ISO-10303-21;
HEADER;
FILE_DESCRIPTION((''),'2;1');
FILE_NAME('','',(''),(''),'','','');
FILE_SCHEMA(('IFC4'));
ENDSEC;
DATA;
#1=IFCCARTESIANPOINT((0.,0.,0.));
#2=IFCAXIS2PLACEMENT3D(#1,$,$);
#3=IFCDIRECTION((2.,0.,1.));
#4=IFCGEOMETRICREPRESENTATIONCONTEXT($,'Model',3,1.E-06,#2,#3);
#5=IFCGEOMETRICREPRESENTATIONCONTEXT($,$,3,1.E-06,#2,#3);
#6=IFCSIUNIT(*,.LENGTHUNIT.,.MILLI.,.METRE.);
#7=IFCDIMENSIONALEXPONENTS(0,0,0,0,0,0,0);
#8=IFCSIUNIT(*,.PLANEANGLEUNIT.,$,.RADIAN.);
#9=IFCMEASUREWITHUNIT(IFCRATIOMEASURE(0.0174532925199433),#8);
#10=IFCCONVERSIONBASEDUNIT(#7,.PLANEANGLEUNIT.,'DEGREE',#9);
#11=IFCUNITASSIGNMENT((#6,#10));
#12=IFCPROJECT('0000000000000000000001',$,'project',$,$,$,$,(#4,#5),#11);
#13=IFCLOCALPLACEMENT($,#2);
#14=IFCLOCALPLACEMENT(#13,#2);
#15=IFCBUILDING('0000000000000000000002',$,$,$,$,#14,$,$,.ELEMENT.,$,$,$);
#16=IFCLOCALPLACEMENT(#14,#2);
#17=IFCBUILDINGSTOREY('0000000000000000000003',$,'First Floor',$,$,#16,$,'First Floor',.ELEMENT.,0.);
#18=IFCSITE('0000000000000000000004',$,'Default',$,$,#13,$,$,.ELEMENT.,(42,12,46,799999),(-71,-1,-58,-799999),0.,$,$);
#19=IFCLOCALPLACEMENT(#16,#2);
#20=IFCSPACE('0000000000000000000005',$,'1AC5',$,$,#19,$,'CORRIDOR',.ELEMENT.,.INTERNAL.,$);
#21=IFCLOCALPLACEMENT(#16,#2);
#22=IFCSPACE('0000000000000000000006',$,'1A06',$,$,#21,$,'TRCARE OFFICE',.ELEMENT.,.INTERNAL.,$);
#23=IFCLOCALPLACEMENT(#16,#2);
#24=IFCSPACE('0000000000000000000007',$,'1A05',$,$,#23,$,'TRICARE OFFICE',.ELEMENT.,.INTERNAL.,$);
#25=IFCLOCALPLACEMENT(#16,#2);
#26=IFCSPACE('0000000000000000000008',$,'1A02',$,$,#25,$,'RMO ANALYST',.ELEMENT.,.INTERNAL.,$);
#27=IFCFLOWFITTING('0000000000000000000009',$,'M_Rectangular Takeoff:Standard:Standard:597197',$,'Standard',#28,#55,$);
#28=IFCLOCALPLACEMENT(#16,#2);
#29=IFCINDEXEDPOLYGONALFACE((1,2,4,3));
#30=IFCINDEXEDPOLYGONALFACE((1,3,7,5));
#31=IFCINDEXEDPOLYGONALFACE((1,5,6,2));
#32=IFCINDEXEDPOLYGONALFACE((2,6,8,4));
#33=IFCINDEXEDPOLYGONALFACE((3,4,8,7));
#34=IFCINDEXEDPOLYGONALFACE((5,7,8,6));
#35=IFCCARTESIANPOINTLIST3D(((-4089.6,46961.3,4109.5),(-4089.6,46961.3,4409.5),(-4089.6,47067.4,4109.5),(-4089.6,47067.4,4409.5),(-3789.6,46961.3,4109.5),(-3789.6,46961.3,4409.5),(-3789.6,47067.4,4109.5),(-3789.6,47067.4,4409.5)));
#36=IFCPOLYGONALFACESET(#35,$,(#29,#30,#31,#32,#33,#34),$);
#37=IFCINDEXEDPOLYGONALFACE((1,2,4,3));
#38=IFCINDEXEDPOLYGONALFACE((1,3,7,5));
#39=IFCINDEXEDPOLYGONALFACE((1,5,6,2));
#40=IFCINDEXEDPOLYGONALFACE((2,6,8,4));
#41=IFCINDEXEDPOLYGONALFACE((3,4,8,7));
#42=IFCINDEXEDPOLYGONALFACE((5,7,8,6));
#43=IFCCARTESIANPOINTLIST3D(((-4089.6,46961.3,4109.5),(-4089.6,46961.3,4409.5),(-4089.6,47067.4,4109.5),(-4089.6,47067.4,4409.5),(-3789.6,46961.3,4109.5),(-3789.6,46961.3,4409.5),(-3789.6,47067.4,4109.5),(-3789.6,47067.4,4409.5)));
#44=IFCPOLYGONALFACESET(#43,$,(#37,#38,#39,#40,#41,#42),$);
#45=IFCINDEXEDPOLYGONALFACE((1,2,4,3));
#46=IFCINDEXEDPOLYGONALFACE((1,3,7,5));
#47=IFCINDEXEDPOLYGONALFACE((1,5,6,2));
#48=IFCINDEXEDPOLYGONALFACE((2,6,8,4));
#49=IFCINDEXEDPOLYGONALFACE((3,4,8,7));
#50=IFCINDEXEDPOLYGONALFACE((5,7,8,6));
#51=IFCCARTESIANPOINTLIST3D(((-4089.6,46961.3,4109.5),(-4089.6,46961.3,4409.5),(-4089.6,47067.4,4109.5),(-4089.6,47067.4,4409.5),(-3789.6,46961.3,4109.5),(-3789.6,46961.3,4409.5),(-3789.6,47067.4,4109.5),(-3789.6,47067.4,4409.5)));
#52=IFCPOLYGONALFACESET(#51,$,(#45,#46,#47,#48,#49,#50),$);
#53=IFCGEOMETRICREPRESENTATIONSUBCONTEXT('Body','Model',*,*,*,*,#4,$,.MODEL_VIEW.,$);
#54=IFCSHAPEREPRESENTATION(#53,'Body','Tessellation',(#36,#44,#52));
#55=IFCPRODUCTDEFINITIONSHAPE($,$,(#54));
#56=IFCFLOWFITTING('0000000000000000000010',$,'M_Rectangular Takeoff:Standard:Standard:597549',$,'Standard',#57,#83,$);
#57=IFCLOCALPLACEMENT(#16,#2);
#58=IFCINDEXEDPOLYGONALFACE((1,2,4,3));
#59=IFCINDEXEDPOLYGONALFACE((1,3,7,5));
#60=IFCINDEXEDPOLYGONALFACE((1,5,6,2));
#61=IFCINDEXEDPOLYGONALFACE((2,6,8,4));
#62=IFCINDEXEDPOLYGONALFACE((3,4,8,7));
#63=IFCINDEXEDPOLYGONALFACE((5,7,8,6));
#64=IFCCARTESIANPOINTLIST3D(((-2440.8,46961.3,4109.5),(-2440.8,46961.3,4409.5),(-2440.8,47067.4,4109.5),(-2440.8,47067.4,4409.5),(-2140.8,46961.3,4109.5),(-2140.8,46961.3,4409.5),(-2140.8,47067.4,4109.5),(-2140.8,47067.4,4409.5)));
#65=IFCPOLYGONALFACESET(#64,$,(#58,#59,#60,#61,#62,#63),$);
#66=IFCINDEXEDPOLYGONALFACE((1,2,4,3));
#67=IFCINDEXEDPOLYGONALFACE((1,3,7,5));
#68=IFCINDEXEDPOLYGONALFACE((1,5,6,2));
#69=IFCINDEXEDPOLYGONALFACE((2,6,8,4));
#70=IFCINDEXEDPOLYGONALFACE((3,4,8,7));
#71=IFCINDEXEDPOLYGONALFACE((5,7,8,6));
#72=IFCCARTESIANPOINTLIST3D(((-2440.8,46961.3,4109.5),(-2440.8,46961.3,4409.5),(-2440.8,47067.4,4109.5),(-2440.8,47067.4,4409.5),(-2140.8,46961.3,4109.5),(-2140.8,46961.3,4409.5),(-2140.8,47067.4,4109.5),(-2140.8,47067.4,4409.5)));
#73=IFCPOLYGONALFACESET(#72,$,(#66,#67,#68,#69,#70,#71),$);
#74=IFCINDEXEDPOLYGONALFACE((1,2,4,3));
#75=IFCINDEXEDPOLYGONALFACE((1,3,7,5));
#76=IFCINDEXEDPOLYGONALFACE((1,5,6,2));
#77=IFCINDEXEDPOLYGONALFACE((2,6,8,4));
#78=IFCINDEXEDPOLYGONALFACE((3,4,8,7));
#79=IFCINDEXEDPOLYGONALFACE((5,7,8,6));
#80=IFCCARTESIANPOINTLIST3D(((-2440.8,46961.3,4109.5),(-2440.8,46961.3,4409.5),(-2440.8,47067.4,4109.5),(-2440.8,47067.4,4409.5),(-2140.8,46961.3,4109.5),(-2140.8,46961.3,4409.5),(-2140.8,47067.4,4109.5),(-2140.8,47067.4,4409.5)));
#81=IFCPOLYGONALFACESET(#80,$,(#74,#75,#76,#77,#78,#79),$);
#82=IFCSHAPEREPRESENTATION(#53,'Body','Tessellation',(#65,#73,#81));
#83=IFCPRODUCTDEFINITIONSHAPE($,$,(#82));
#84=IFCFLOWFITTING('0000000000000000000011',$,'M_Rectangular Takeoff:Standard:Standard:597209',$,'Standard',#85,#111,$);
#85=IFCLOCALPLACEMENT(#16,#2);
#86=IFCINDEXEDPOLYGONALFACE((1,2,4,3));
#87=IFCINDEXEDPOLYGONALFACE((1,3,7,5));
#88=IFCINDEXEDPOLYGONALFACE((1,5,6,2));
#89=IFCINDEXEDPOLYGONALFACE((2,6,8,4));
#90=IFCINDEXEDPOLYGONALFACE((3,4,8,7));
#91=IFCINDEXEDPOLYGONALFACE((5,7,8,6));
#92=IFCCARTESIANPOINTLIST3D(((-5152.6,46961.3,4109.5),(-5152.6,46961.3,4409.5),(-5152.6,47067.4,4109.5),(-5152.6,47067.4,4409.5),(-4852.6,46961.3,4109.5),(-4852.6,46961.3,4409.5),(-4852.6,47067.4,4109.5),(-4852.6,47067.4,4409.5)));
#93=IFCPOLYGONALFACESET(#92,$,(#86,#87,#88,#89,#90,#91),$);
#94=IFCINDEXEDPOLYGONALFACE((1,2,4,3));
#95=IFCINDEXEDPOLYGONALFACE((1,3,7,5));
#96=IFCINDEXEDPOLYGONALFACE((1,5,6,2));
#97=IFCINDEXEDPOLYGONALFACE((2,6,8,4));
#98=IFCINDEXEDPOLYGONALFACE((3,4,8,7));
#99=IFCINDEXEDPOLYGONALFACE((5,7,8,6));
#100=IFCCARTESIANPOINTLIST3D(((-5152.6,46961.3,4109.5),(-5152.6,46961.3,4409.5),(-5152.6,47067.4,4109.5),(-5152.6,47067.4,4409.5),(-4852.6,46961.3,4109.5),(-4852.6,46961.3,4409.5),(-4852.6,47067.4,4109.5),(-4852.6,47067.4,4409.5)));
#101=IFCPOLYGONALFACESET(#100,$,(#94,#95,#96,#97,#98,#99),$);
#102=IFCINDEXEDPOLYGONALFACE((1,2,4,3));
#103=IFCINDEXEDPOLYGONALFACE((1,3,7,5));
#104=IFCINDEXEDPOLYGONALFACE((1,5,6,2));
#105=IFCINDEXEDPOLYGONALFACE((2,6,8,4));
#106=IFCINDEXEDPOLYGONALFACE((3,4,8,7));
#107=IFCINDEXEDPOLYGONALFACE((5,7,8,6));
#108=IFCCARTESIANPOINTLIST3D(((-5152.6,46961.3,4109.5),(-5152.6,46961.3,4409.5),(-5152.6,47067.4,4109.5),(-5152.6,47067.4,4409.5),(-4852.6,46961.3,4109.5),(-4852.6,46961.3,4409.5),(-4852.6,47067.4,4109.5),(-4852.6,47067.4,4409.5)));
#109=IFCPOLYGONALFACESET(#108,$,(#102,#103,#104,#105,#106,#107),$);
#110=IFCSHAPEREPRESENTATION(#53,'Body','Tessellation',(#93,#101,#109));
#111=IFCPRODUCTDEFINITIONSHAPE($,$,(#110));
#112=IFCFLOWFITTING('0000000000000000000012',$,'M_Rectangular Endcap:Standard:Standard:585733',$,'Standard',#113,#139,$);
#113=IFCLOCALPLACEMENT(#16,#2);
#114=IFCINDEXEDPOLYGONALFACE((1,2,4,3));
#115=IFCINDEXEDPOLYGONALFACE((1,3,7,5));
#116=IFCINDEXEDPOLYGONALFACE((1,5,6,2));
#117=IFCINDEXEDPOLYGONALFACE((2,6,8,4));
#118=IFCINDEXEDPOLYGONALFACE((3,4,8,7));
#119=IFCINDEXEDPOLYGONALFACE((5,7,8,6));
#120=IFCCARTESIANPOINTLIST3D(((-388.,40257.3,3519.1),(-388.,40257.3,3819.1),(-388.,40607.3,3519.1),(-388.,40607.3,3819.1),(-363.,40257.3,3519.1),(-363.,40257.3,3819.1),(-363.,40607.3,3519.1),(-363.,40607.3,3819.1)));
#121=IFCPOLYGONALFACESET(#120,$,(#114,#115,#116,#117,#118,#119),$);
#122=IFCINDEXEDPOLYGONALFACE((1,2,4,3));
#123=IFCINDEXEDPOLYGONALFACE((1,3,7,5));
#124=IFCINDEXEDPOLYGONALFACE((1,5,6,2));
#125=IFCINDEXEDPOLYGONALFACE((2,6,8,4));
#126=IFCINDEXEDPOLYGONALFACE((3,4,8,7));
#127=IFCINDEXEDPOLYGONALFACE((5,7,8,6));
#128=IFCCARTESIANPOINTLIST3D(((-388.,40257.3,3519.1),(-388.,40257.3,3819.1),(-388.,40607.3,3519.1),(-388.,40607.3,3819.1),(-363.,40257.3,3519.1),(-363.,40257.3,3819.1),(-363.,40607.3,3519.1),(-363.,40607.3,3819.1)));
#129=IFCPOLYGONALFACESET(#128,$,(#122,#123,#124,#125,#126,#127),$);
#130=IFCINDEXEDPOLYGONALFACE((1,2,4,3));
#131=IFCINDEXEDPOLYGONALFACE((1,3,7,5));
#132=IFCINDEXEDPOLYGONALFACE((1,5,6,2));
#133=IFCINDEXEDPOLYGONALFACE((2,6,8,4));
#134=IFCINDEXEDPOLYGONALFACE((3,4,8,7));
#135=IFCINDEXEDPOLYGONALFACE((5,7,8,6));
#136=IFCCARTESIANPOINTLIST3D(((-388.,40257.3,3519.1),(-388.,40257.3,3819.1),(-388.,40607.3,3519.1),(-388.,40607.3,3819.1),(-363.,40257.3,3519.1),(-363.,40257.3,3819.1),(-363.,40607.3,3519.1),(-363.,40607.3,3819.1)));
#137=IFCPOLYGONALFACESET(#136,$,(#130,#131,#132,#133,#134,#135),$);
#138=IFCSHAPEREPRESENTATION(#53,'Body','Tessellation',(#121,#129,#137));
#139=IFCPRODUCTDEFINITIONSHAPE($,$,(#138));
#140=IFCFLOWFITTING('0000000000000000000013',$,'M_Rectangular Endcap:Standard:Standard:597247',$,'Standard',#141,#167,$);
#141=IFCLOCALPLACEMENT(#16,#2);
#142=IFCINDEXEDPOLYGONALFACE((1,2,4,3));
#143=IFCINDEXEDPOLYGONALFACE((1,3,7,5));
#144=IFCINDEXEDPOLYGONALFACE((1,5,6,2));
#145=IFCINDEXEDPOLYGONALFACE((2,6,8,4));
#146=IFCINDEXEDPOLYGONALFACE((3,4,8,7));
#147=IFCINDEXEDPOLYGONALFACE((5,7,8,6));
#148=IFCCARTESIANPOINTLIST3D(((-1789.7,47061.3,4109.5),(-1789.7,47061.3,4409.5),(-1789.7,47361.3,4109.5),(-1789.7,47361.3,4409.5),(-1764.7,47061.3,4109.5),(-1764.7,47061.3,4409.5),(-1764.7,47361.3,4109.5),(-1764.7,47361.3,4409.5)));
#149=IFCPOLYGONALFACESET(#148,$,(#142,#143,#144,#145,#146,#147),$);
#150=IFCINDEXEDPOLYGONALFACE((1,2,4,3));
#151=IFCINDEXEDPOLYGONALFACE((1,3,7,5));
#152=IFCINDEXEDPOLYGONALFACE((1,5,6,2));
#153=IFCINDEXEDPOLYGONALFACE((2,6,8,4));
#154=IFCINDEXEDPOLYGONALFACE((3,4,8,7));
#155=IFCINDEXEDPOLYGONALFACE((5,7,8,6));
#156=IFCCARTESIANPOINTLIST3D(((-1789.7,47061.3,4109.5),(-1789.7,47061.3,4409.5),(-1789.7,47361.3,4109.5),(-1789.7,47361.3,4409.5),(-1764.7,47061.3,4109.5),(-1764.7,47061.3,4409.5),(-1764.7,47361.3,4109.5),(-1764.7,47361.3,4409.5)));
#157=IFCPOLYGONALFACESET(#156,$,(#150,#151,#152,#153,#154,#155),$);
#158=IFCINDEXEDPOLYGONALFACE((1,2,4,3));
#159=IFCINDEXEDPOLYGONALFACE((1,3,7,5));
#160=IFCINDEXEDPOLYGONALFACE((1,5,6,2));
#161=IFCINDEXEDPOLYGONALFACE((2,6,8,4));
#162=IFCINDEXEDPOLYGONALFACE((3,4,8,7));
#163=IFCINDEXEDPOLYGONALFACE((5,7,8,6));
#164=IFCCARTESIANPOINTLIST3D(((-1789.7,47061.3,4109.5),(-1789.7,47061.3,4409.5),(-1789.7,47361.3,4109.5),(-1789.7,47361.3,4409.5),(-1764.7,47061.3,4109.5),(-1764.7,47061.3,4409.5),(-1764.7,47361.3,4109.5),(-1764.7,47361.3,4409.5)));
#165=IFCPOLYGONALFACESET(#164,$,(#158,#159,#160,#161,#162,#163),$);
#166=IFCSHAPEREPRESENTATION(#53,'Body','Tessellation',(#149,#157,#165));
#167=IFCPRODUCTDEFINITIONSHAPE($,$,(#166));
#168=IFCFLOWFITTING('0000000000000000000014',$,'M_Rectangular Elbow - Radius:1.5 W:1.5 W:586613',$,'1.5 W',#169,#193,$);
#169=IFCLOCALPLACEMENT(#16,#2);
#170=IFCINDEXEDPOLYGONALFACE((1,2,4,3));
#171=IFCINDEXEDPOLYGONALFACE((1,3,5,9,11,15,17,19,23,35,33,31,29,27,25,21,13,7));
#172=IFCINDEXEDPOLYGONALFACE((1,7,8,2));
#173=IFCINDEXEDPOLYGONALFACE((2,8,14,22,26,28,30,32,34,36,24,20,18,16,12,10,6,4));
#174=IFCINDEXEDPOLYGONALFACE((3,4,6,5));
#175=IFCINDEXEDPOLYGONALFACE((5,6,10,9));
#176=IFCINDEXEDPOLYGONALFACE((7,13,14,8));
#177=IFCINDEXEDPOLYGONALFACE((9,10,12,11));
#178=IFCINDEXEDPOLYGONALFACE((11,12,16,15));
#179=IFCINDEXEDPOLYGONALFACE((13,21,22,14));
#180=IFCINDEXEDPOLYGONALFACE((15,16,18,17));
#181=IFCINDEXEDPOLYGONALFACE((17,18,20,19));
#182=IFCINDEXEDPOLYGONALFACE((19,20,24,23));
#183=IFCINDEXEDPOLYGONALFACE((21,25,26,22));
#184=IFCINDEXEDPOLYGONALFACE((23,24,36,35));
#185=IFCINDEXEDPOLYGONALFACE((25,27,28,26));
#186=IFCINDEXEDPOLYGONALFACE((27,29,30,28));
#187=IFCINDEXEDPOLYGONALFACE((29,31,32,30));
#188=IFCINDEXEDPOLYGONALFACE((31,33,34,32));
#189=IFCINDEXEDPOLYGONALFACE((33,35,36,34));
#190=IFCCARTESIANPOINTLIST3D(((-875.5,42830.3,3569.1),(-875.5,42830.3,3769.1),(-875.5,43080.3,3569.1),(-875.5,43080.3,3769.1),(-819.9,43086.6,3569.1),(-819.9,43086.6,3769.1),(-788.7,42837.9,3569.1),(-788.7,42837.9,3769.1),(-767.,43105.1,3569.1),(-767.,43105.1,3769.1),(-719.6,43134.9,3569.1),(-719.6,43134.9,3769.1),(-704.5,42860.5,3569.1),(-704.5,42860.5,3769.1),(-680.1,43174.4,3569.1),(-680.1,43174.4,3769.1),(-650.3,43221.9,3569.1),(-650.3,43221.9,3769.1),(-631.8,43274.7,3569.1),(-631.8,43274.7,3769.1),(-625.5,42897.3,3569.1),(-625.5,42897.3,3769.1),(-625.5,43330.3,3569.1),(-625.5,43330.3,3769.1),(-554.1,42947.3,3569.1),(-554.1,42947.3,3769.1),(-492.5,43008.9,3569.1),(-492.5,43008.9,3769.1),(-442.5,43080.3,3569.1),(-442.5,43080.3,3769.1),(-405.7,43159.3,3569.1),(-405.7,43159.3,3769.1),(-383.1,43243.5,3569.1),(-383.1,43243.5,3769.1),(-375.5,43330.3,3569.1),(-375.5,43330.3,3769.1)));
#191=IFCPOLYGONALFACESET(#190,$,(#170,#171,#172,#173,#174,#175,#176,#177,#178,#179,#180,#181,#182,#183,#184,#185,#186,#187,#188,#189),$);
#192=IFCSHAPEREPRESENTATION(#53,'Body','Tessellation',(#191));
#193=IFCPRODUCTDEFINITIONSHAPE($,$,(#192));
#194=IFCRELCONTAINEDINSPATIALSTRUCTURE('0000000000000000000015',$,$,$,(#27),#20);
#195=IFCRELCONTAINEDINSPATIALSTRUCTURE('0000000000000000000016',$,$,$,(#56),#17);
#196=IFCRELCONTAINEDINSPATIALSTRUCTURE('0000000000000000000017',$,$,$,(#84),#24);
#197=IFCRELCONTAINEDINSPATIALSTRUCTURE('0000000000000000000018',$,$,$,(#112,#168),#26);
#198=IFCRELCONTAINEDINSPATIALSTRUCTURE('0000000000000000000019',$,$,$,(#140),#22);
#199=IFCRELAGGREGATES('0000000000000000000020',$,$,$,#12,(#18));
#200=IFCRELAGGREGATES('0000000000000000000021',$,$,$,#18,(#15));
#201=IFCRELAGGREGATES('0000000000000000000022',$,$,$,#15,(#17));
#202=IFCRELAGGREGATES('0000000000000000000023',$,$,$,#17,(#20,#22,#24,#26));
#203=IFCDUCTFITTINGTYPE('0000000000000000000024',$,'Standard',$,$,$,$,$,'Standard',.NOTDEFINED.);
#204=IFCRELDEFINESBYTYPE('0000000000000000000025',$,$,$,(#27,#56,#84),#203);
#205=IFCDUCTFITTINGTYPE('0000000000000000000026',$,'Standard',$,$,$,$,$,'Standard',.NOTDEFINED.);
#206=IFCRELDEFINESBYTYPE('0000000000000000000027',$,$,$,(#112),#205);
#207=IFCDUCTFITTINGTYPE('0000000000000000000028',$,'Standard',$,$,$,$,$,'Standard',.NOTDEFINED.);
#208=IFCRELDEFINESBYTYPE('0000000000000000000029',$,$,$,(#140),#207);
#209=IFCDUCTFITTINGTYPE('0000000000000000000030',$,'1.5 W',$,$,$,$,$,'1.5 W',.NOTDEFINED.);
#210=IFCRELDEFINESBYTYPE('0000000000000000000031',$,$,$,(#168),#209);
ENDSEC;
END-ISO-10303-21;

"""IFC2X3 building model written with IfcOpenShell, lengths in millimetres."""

from ifc_helpers import new_model, entity, si_unit, converted_unit, direction, frame, frame_2d, origin, origin_2d_with_axis, place, context, subcontext, project, spatial, polyline, circle_curve, parameter, trimmed, segment, composite_curve, rectangle, outline, extrude, source, transform, mapped, type_object, type_shapes, element, save


model = new_model("IFC2X3")

# Units and contexts
model_context = context("Model", 3, precision=1e-06, world=origin(), true_north=direction((2.0, 0.0, 1.0)))
context_of_model = context(None, 3, precision=1e-06, world=origin(), true_north=direction((2.0, 0.0, 1.0)))
body_context = subcontext(model_context, "Body", "Model", "MODEL_VIEW")
ifc_project = project(units=[si_unit("LENGTHUNIT", "METRE", prefix="MILLI"), converted_unit("PLANEANGLEUNIT", "DEGREE", entity("IfcRatioMeasure", 0.0174532925199433), si_unit("PLANEANGLEUNIT", "RADIAN"), dimensions=[0, 0, 0, 0, 0, 0, 0])], contexts=[model_context, context_of_model])

# Site, building, storey
site_placement = place(None, origin())
site = spatial("IfcSite", under=ifc_project, at=site_placement, Name="Default", CompositionType="ELEMENT", RefLatitude=(42, 12, 46, 799999), RefLongitude=(-71, -1, -58, -799999), RefElevation=0.0)
building_placement = place(site_placement, origin())
building = spatial("IfcBuilding", under=site, at=building_placement, CompositionType="ELEMENT")
storey_placement = place(building_placement, origin())
storey = spatial("IfcBuildingStorey", under=building, at=storey_placement, Name="First Floor", LongName="First Floor", CompositionType="ELEMENT", Elevation=0.0)

# Shared definitions
space_1_placement = place(storey_placement, origin())
space_1 = spatial("IfcSpace", under=storey, at=space_1_placement, Name="1AC5", LongName="CORRIDOR", CompositionType="ELEMENT", InteriorOrExteriorSpace="INTERNAL")

# Shared definitions
space_2_placement = place(storey_placement, origin())
space_2 = spatial("IfcSpace", under=storey, at=space_2_placement, Name="1A06", LongName="TRCARE OFFICE", CompositionType="ELEMENT", InteriorOrExteriorSpace="INTERNAL")

# Shared definitions
space_3_placement = place(storey_placement, origin())
space_3 = spatial("IfcSpace", under=storey, at=space_3_placement, Name="1A05", LongName="TRICARE OFFICE", CompositionType="ELEMENT", InteriorOrExteriorSpace="INTERNAL")

# Flow fittings
duct_fitting_type_1 = type_object("IfcDuctFittingType", Name="Standard", ElementType="Standard", PredefinedType="NOTDEFINED")
shared_shape_1 = source(origin(), body_context, "Body", "SweptSolid", [
    extrude(rectangle(XDim=106.1, YDim=300.0, at=frame_2d((0.0, 0.0), x_axis=(1.0, 0.0))), frame((47.0, 0.0, -150.0)), (0.0, 0.0, 1.0), 300.0),
    extrude(rectangle(XDim=106.1, YDim=300.0, at=frame_2d((0.0, 0.0), x_axis=(1.0, 0.0))), frame((47.0, 0.0, -150.0)), (0.0, 0.0, 1.0), 300.0),
    extrude(rectangle(XDim=106.1, YDim=300.0, at=frame_2d((0.0, 0.0), x_axis=(1.0, 0.0))), frame((47.0, 0.0, -150.0)), (0.0, 0.0, 1.0), 300.0),
])
type_shapes(duct_fitting_type_1, [shared_shape_1])
flow_fitting_1_placement = place(space_1_placement, frame((-3939.6, 47061.3, 4259.5), z_axis=(0.0, 0.0, -1.0), x_axis=(0.0, -1.0, 0.0)))
element("IfcFlowFitting", 1, at=flow_fitting_1_placement, inside=space_1, type_object=duct_fitting_type_1, Name="M_Rectangular Takeoff:Standard:Standard:597197", ObjectType="Standard", context=body_context, shape_type="MappedRepresentation", body=[
    mapped(shared_shape_1, transform((0.0, 0.0, 0.0), scale=1.0)),
])
flow_fitting_2_placement = place(storey_placement, frame((-2290.8, 47061.3, 4259.5), z_axis=(0.0, 0.0, 1.0), x_axis=(0.0, -1.0, 0.0)))
element("IfcFlowFitting", 2, at=flow_fitting_2_placement, inside=storey, type_object=duct_fitting_type_1, Name="M_Rectangular Takeoff:Standard:Standard:597549", ObjectType="Standard", context=body_context, shape_type="MappedRepresentation", body=[
    mapped(shared_shape_1, transform((0.0, 0.0, 0.0), scale=1.0)),
])
flow_fitting_3_placement = place(space_3_placement, frame((-5002.6, 47061.3, 4259.5), z_axis=(0.0, 0.0, -1.0), x_axis=(0.0, -1.0, 0.0)))
element("IfcFlowFitting", 3, at=flow_fitting_3_placement, inside=space_3, type_object=duct_fitting_type_1, Name="M_Rectangular Takeoff:Standard:Standard:597209", ObjectType="Standard", context=body_context, shape_type="MappedRepresentation", body=[
    mapped(shared_shape_1, transform((0.0, 0.0, 0.0), scale=1.0)),
])

# Shared definitions
space_4_placement = place(storey_placement, origin())
space_4 = spatial("IfcSpace", under=storey, at=space_4_placement, Name="1A02", LongName="RMO ANALYST", CompositionType="ELEMENT", InteriorOrExteriorSpace="INTERNAL")

# Flow fittings
duct_fitting_type_2 = type_object("IfcDuctFittingType", Name="Standard", ElementType="Standard", PredefinedType="NOTDEFINED")
shared_shape_2 = source(origin(), body_context, "Body", "SweptSolid", [
    extrude(rectangle(XDim=25.0, YDim=350.0, at=origin_2d_with_axis()), frame((12.5, 0.0, -150.0)), (0.0, 0.0, 1.0), 300.0),
    extrude(rectangle(XDim=25.0, YDim=350.0, at=origin_2d_with_axis()), frame((12.5, 0.0, -150.0)), (0.0, 0.0, 1.0), 300.0),
    extrude(rectangle(XDim=25.0, YDim=350.0, at=frame_2d((0.0, 0.0), x_axis=(1.0, 0.0))), frame((12.5, 0.0, -150.0)), (0.0, 0.0, 1.0), 300.0),
])
type_shapes(duct_fitting_type_2, [shared_shape_2])
flow_fitting_4_placement = place(space_4_placement, frame((-388.0, 40432.3, 3669.1)))
element("IfcFlowFitting", 4, at=flow_fitting_4_placement, inside=space_4, type_object=duct_fitting_type_2, Name="M_Rectangular Endcap:Standard:Standard:585733", ObjectType="Standard", context=body_context, shape_type="MappedRepresentation", body=[
    mapped(shared_shape_2, transform((0.0, 0.0, 0.0), scale=1.0)),
])
duct_fitting_type_3 = type_object("IfcDuctFittingType", Name="Standard", ElementType="Standard", PredefinedType="NOTDEFINED")
shared_shape_3 = source(origin(), body_context, "Body", "SweptSolid", [
    extrude(rectangle(XDim=25.0, YDim=300.0, at=origin_2d_with_axis()), frame((12.5, 0.0, -150.0)), (0.0, 0.0, 1.0), 300.0),
    extrude(rectangle(XDim=25.0, YDim=300.0, at=origin_2d_with_axis()), frame((12.5, 0.0, -150.0)), (0.0, 0.0, 1.0), 300.0),
    extrude(rectangle(XDim=25.0, YDim=300.0, at=frame_2d((0.0, 0.0), x_axis=(1.0, 0.0))), frame((12.5, 0.0, -150.0)), (0.0, 0.0, 1.0), 300.0),
])
type_shapes(duct_fitting_type_3, [shared_shape_3])
flow_fitting_5_placement = place(space_2_placement, frame((-1789.7, 47211.3, 4259.5)))
element("IfcFlowFitting", 5, at=flow_fitting_5_placement, inside=space_2, type_object=duct_fitting_type_3, Name="M_Rectangular Endcap:Standard:Standard:597247", ObjectType="Standard", context=body_context, shape_type="MappedRepresentation", body=[
    mapped(shared_shape_3, transform((0.0, 0.0, 0.0), scale=1.0)),
])
duct_fitting_type_4 = type_object("IfcDuctFittingType", Name="1.5 W", ElementType="1.5 W", PredefinedType="NOTDEFINED")
shared_shape_4 = source(origin(), body_context, "Body", "SweptSolid", [
    extrude(outline(composite_curve([segment(polyline([(-312.5, -187.5), (-62.5, -187.5)]), True, "CONTINUOUS"), segment(trimmed(circle_curve(frame_2d((187.5, -187.5), x_axis=(0.0, 1.0)), 250.0), [parameter(0.0)], [parameter(90.0)], True, "PARAMETER"), False, "CONTINUOUS"), segment(polyline([(187.5, 62.5), (187.5, 312.5)]), True, "CONTINUOUS"), segment(trimmed(circle_curve(frame_2d((187.5, -187.5), x_axis=(0.0, 1.0)), 500.0), [parameter(0.0)], [parameter(90.0)], True, "PARAMETER"), True, "CONTINUOUS")], self_intersect=False)), frame((-187.5, 187.5, -100.0), z_axis=(0.0, 0.0, 1.0), x_axis=(-1.0, 0.0, 0.0)), (0.0, 0.0, 1.0), 200.0),
])
type_shapes(duct_fitting_type_4, [shared_shape_4])
flow_fitting_6_placement = place(space_4_placement, frame((-500.5, 42955.3, 3669.1)))
element("IfcFlowFitting", 6, at=flow_fitting_6_placement, inside=space_4, type_object=duct_fitting_type_4, Name="M_Rectangular Elbow - Radius:1.5 W:1.5 W:586613", ObjectType="1.5 W", context=body_context, shape_type="MappedRepresentation", body=[
    mapped(shared_shape_4, transform((0.0, 0.0, 0.0), scale=1.0)),
])

save(model, "model.ifc")
